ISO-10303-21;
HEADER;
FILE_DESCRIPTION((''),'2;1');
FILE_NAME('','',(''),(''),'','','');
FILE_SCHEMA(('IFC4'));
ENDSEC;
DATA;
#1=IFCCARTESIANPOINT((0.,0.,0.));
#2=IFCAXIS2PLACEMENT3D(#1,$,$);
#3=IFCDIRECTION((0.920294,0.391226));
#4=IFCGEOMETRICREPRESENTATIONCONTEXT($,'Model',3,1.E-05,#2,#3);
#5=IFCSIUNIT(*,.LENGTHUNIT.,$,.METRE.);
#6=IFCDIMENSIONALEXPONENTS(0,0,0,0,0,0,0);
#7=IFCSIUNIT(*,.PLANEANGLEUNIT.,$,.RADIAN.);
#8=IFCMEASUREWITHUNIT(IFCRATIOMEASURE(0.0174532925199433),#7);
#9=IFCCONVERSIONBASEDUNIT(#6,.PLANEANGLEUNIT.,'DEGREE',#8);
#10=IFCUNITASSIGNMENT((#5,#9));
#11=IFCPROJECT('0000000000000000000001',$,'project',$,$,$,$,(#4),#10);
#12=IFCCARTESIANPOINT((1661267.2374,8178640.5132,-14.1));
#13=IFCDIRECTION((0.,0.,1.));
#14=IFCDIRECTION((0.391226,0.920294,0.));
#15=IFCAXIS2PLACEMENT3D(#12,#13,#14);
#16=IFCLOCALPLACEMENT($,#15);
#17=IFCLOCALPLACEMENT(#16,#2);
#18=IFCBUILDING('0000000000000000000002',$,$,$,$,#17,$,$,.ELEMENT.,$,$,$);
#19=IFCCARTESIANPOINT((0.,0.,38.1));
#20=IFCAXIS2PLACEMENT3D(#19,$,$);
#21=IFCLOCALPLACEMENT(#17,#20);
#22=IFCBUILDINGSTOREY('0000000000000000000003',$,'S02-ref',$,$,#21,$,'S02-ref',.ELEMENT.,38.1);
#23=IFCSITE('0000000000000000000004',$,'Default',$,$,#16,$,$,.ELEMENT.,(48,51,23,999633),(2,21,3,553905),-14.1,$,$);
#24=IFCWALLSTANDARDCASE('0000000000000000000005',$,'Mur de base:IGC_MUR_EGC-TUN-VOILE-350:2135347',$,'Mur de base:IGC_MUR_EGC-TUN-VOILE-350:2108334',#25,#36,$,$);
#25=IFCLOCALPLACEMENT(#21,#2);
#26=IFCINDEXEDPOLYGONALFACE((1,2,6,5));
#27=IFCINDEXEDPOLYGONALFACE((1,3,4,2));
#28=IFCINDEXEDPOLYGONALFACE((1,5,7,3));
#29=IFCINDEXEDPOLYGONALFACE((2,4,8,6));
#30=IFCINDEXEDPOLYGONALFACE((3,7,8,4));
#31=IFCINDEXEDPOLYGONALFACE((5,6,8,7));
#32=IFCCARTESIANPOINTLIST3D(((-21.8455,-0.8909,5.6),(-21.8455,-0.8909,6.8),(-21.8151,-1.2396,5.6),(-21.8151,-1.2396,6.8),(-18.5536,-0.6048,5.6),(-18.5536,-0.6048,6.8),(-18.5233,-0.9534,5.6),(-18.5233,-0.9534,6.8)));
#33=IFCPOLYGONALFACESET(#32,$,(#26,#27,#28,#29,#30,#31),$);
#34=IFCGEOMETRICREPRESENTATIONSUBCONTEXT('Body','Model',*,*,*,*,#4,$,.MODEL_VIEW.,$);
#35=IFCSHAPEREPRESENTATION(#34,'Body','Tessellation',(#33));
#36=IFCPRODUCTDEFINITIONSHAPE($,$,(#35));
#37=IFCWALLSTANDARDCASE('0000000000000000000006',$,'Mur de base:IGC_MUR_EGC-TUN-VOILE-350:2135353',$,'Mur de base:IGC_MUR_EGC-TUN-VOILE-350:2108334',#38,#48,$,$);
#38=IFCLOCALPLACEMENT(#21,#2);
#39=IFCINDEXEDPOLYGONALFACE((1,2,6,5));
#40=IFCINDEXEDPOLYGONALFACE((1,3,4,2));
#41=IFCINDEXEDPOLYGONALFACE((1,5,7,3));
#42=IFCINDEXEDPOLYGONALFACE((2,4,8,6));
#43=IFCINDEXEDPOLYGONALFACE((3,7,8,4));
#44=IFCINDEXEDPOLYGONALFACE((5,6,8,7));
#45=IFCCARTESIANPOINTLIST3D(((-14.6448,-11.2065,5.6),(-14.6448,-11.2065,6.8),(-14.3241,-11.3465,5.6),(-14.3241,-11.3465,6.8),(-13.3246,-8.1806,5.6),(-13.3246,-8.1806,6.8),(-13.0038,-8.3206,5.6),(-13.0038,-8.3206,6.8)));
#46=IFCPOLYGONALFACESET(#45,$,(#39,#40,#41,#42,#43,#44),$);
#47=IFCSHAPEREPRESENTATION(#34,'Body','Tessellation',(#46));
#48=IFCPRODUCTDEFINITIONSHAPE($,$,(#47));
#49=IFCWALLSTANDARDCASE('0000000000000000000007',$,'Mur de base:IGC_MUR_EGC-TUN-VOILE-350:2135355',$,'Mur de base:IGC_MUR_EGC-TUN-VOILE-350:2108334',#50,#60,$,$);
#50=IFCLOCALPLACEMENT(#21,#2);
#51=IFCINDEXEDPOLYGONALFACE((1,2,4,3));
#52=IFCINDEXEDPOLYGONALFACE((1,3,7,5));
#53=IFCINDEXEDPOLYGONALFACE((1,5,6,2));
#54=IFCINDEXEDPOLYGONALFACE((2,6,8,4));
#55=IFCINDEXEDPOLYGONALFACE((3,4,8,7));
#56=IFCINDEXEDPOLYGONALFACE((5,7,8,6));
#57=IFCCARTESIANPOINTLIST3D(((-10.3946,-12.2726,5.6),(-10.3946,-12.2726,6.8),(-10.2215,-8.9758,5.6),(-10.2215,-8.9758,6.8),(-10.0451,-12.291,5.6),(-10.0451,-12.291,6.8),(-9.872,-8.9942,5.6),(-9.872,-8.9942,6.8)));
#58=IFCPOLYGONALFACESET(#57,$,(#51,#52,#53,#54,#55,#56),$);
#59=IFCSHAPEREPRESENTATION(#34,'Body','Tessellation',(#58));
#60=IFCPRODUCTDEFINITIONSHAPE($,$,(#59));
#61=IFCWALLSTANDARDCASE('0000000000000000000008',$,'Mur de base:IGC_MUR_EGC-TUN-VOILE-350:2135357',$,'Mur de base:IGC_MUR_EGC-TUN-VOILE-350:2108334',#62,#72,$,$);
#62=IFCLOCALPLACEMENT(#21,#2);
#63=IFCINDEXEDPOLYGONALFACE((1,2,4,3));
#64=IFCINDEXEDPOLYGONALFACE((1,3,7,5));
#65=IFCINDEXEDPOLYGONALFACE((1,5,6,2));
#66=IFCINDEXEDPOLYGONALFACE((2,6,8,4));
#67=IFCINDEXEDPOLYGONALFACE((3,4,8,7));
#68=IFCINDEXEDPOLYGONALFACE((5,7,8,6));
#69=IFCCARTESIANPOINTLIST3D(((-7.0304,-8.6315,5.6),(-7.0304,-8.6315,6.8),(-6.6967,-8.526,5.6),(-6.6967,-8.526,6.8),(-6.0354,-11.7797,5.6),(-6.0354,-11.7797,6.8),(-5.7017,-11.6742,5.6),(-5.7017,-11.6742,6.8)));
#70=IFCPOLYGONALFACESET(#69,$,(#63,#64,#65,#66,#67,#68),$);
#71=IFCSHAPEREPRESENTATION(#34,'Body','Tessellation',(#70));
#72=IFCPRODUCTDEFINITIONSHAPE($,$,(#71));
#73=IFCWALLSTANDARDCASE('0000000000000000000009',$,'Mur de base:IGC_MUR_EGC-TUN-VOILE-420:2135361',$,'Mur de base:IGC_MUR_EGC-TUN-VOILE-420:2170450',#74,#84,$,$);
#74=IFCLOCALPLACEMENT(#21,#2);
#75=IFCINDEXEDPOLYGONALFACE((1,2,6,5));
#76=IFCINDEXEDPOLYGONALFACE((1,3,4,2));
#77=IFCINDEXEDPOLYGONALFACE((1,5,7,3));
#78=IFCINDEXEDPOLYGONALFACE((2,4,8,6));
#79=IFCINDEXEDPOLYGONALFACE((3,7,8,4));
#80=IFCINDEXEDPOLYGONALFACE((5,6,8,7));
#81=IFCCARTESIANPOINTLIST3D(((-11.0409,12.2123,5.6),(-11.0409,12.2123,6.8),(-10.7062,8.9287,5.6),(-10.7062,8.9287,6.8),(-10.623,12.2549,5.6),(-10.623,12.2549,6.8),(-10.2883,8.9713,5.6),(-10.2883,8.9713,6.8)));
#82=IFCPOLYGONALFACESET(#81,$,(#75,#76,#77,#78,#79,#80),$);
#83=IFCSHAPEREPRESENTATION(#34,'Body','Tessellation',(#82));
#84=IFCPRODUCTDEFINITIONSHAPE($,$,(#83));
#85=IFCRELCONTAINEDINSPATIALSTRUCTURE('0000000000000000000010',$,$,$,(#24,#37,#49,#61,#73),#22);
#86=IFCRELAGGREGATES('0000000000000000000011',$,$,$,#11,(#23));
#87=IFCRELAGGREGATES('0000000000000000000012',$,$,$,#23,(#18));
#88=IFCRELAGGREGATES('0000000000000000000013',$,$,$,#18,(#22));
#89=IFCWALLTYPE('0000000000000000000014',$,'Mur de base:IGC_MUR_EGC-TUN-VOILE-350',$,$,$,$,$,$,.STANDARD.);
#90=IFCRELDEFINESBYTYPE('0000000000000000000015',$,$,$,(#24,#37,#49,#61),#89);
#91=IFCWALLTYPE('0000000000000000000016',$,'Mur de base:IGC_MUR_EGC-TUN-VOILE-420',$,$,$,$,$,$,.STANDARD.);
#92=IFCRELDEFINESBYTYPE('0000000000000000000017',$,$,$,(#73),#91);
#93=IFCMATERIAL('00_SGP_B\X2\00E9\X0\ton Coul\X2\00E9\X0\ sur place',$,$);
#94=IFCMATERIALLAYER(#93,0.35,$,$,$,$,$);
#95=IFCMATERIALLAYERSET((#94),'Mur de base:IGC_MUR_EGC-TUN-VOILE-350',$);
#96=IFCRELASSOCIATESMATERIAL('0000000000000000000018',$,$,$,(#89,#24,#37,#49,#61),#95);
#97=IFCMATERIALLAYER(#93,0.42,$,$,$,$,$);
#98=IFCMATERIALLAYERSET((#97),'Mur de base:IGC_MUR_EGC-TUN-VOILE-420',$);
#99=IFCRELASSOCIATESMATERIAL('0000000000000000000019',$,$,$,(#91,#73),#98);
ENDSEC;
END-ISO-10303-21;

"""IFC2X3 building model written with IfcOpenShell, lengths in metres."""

from ifc_helpers import new_model, entity, si_unit, converted_unit, direction, frame, frame_2d, origin, place, context, subcontext, project, spatial, rectangle, extrude, material, layer, layer_set, layer_usage, type_object, element, save


model = new_model("IFC2X3")

# Units and contexts
model_context = context("Model", 3, precision=1e-05, world=origin(), true_north=direction((0.920294, 0.391226)))
body_context = subcontext(model_context, "Body", "Model", "MODEL_VIEW")
ifc_project = project(units=[si_unit("LENGTHUNIT", "METRE"), converted_unit("PLANEANGLEUNIT", "DEGREE", entity("IfcRatioMeasure", 0.0174532925199433), si_unit("PLANEANGLEUNIT", "RADIAN"), dimensions=[0, 0, 0, 0, 0, 0, 0])], contexts=[model_context])

# Site, building, storey
site_placement = place(None, frame((1661267.2374, 8178640.5132, -14.1), z_axis=(0.0, 0.0, 1.0), x_axis=(0.391226, 0.920294, 0.0)))
site = spatial("IfcSite", under=ifc_project, at=site_placement, Name="Default", CompositionType="ELEMENT", RefLatitude=(48, 51, 23, 999633), RefLongitude=(2, 21, 3, 553905), RefElevation=-14.1)
building_placement = place(site_placement, origin())
building = spatial("IfcBuilding", under=site, at=building_placement, CompositionType="ELEMENT")
storey_placement = place(building_placement, frame((0.0, 0.0, 38.1)))
storey = spatial("IfcBuildingStorey", under=building, at=storey_placement, Name="S02-ref", LongName="S02-ref", CompositionType="ELEMENT", Elevation=38.1)

# Walls
ifc_material_1 = material(Name="00_SGP_Béton Coulé sur place")
ifc_layer_1 = layer(ifc_material_1, 0.35)
ifc_layer_set_1 = layer_set([ifc_layer_1], Name="Mur de base:IGC_MUR_EGC-TUN-VOILE-350")
ifc_layer_usage_1 = layer_usage(ifc_layer_set_1, "AXIS2", "POSITIVE", -0.175)
wall_type_1 = type_object("IfcWallType", Name="Mur de base:IGC_MUR_EGC-TUN-VOILE-350", PredefinedType="STANDARD", material=ifc_layer_set_1)
wall_1_placement = place(storey_placement, frame((-18.5385, -0.7791, 5.6), z_axis=(0.0, 0.0, 1.0), x_axis=(-0.996243, -0.086607, 0.0)))
element("IfcWallStandardCase", 1, at=wall_1_placement, inside=storey, type_object=wall_type_1, material=ifc_layer_usage_1, Name="Mur de base:IGC_MUR_EGC-TUN-VOILE-350:2135347", ObjectType="Mur de base:IGC_MUR_EGC-TUN-VOILE-350:2108334", context=body_context, shape_type="SweptSolid", body=[
    extrude(rectangle(XDim=3.3043, YDim=0.35, at=frame_2d((1.6521, 0.0), x_axis=(-1.0, 0.0))), origin(), (0.0, 0.0, 1.0), 1.2),
])
ifc_layer_usage_2 = layer_usage(ifc_layer_set_1, "AXIS2", "POSITIVE", -0.175)
wall_2_placement = place(storey_placement, frame((-13.1642, -8.2506, 5.6), z_axis=(0.0, 0.0, 1.0), x_axis=(-0.39991, -0.916554, 0.0)))
element("IfcWallStandardCase", 2, at=wall_2_placement, inside=storey, type_object=wall_type_1, material=ifc_layer_usage_2, Name="Mur de base:IGC_MUR_EGC-TUN-VOILE-350:2135353", ObjectType="Mur de base:IGC_MUR_EGC-TUN-VOILE-350:2108334", context=body_context, shape_type="SweptSolid", body=[
    extrude(rectangle(XDim=3.3014, YDim=0.35, at=frame_2d((1.6507, 0.0), x_axis=(-1.0, 0.0))), origin(), (0.0, 0.0, 1.0), 1.2),
])
ifc_layer_usage_3 = layer_usage(ifc_layer_set_1, "AXIS2", "POSITIVE", -0.175)
wall_3_placement = place(storey_placement, frame((-10.0468, -8.985, 5.6), z_axis=(0.0, 0.0, 1.0), x_axis=(-0.052435, -0.998624, 0.0)))
element("IfcWallStandardCase", 3, at=wall_3_placement, inside=storey, type_object=wall_type_1, material=ifc_layer_usage_3, Name="Mur de base:IGC_MUR_EGC-TUN-VOILE-350:2135355", ObjectType="Mur de base:IGC_MUR_EGC-TUN-VOILE-350:2108334", context=body_context, shape_type="SweptSolid", body=[
    extrude(rectangle(XDim=3.3014, YDim=0.35, at=frame_2d((1.6507, 0.0), x_axis=(-1.0, 0.0))), origin(), (0.0, 0.0, 1.0), 1.2),
])
ifc_layer_usage_4 = layer_usage(ifc_layer_set_1, "AXIS2", "POSITIVE", -0.175)
wall_4_placement = place(storey_placement, frame((-6.8636, -8.5787, 5.6), z_axis=(0.0, 0.0, 1.0), x_axis=(0.301365, -0.953509, 0.0)))
element("IfcWallStandardCase", 4, at=wall_4_placement, inside=storey, type_object=wall_type_1, material=ifc_layer_usage_4, Name="Mur de base:IGC_MUR_EGC-TUN-VOILE-350:2135357", ObjectType="Mur de base:IGC_MUR_EGC-TUN-VOILE-350:2108334", context=body_context, shape_type="SweptSolid", body=[
    extrude(rectangle(XDim=3.3017, YDim=0.35, at=frame_2d((1.6508, 0.0), x_axis=(-1.0, 0.0))), origin(), (0.0, 0.0, 1.0), 1.2),
])
ifc_layer_2 = layer(ifc_material_1, 0.42)
ifc_layer_set_2 = layer_set([ifc_layer_2], Name="Mur de base:IGC_MUR_EGC-TUN-VOILE-420")
ifc_layer_usage_5 = layer_usage(ifc_layer_set_2, "AXIS2", "POSITIVE", -0.21)
wall_type_2 = type_object("IfcWallType", Name="Mur de base:IGC_MUR_EGC-TUN-VOILE-420", PredefinedType="STANDARD", material=ifc_layer_set_2)
wall_5_placement = place(storey_placement, frame((-10.4973, 8.95, 5.6), z_axis=(0.0, 0.0, 1.0), x_axis=(-0.101398, 0.994846, 0.0)))
element("IfcWallStandardCase", 5, at=wall_5_placement, inside=storey, type_object=wall_type_2, material=ifc_layer_usage_5, Name="Mur de base:IGC_MUR_EGC-TUN-VOILE-420:2135361", ObjectType="Mur de base:IGC_MUR_EGC-TUN-VOILE-420:2170450", context=body_context, shape_type="SweptSolid", body=[
    extrude(rectangle(XDim=3.3006, YDim=0.42, at=frame_2d((1.6503, 0.0), x_axis=(-1.0, 0.0))), origin(), (0.0, 0.0, 1.0), 1.2),
])

save(model, "model.ifc")
